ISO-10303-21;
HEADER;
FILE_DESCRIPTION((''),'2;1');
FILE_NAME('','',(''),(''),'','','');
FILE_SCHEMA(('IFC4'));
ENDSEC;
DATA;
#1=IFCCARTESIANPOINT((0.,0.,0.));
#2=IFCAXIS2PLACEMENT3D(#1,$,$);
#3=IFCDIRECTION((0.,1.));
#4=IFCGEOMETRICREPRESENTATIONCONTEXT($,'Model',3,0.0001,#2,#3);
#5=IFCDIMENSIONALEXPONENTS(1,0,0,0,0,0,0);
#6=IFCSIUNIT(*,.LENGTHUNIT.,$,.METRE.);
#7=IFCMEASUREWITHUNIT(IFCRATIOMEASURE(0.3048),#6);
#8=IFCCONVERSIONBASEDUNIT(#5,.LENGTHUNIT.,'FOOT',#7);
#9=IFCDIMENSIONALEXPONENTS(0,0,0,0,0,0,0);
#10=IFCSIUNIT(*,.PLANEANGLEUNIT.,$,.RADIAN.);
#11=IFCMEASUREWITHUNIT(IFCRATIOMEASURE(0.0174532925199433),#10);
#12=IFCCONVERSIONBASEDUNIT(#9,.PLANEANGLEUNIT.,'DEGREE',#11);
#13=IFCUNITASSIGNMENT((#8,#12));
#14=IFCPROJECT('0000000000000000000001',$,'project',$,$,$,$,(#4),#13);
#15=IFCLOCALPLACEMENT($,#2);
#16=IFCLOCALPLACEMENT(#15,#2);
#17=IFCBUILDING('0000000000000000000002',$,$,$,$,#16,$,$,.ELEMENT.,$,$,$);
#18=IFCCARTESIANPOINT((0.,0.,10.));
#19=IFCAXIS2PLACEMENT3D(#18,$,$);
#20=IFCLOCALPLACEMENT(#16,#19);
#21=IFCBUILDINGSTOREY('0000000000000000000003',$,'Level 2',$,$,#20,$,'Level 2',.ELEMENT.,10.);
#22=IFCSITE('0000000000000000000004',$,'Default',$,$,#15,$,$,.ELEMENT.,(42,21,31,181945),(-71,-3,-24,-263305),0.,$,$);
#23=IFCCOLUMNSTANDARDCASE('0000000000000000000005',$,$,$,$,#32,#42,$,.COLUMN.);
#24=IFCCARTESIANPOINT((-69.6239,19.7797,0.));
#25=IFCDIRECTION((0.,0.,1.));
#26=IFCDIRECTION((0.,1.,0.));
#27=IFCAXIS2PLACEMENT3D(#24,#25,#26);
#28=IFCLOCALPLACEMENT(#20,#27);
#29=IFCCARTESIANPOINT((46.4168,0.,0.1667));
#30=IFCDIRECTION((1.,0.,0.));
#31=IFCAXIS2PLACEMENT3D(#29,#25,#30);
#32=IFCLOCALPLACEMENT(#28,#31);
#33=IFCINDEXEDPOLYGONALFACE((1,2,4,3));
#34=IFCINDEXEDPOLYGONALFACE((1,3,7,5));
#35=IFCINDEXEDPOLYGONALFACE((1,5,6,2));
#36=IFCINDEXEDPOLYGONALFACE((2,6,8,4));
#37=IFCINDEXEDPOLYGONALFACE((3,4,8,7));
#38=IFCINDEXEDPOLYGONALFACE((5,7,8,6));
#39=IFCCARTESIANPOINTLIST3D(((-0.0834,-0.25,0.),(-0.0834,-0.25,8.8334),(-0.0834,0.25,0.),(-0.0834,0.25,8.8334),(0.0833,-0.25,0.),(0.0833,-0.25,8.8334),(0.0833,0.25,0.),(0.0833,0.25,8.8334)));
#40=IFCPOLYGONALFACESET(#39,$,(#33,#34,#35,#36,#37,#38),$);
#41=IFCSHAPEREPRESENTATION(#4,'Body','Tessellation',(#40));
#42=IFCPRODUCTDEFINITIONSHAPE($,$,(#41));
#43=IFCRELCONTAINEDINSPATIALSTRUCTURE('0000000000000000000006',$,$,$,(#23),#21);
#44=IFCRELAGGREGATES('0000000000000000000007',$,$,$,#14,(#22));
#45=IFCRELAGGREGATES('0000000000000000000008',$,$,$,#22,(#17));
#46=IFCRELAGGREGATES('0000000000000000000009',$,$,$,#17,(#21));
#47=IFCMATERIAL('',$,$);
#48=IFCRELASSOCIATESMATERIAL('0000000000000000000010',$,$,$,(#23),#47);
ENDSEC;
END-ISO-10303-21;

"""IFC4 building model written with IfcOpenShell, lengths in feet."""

from ifc_helpers import new_model, entity, si_unit, converted_unit, direction, frame, origin, place, context, project, spatial, rectangle, extrude, material, element, save


model = new_model("IFC4")

# Units and contexts
model_context = context("Model", 3, precision=0.0001, world=origin(), true_north=direction((0.0, 1.0)))
ifc_project = project(units=[converted_unit("LENGTHUNIT", "FOOT", entity("IfcRatioMeasure", 0.3048), si_unit("LENGTHUNIT", "METRE"), dimensions=[1, 0, 0, 0, 0, 0, 0]), converted_unit("PLANEANGLEUNIT", "DEGREE", entity("IfcRatioMeasure", 0.0174532925199433), si_unit("PLANEANGLEUNIT", "RADIAN"), dimensions=[0, 0, 0, 0, 0, 0, 0])], contexts=[model_context])

# Site, building, storey
site_placement = place(None, origin())
site = spatial("IfcSite", under=ifc_project, at=site_placement, Name="Default", CompositionType="ELEMENT", RefLatitude=(42, 21, 31, 181945), RefLongitude=(-71, -3, -24, -263305), RefElevation=0.0)
building_placement = place(site_placement, origin())
building = spatial("IfcBuilding", under=site, at=building_placement, CompositionType="ELEMENT")
storey_placement = place(building_placement, frame((0.0, 0.0, 10.0)))
storey = spatial("IfcBuildingStorey", under=building, at=storey_placement, Name="Level 2", LongName="Level 2", CompositionType="ELEMENT", Elevation=10.0)

# Column
ifc_material_1 = material(Name="")
placement_1 = place(storey_placement, frame((-69.6239, 19.7797, 0.0), z_axis=(0.0, 0.0, 1.0), x_axis=(0.0, 1.0, 0.0)))
for number, where, z_axis, x_axis in (
    (1, (46.4168, 0.0, 0.1667), (0.0, 0.0, 1.0), (1.0, 0.0, 0.0)),
):
    element("IfcColumnStandardCase", number, at=place(placement_1, frame(where, z_axis=z_axis, x_axis=x_axis)), inside=storey, material=ifc_material_1, PredefinedType="COLUMN", context=model_context, shape_type="SweptSolid", body=[
        extrude(rectangle(XDim=0.1667, YDim=0.5), origin(), (0.0, 0.0, 1.0), 8.8334),
    ])

save(model, "model.ifc")
